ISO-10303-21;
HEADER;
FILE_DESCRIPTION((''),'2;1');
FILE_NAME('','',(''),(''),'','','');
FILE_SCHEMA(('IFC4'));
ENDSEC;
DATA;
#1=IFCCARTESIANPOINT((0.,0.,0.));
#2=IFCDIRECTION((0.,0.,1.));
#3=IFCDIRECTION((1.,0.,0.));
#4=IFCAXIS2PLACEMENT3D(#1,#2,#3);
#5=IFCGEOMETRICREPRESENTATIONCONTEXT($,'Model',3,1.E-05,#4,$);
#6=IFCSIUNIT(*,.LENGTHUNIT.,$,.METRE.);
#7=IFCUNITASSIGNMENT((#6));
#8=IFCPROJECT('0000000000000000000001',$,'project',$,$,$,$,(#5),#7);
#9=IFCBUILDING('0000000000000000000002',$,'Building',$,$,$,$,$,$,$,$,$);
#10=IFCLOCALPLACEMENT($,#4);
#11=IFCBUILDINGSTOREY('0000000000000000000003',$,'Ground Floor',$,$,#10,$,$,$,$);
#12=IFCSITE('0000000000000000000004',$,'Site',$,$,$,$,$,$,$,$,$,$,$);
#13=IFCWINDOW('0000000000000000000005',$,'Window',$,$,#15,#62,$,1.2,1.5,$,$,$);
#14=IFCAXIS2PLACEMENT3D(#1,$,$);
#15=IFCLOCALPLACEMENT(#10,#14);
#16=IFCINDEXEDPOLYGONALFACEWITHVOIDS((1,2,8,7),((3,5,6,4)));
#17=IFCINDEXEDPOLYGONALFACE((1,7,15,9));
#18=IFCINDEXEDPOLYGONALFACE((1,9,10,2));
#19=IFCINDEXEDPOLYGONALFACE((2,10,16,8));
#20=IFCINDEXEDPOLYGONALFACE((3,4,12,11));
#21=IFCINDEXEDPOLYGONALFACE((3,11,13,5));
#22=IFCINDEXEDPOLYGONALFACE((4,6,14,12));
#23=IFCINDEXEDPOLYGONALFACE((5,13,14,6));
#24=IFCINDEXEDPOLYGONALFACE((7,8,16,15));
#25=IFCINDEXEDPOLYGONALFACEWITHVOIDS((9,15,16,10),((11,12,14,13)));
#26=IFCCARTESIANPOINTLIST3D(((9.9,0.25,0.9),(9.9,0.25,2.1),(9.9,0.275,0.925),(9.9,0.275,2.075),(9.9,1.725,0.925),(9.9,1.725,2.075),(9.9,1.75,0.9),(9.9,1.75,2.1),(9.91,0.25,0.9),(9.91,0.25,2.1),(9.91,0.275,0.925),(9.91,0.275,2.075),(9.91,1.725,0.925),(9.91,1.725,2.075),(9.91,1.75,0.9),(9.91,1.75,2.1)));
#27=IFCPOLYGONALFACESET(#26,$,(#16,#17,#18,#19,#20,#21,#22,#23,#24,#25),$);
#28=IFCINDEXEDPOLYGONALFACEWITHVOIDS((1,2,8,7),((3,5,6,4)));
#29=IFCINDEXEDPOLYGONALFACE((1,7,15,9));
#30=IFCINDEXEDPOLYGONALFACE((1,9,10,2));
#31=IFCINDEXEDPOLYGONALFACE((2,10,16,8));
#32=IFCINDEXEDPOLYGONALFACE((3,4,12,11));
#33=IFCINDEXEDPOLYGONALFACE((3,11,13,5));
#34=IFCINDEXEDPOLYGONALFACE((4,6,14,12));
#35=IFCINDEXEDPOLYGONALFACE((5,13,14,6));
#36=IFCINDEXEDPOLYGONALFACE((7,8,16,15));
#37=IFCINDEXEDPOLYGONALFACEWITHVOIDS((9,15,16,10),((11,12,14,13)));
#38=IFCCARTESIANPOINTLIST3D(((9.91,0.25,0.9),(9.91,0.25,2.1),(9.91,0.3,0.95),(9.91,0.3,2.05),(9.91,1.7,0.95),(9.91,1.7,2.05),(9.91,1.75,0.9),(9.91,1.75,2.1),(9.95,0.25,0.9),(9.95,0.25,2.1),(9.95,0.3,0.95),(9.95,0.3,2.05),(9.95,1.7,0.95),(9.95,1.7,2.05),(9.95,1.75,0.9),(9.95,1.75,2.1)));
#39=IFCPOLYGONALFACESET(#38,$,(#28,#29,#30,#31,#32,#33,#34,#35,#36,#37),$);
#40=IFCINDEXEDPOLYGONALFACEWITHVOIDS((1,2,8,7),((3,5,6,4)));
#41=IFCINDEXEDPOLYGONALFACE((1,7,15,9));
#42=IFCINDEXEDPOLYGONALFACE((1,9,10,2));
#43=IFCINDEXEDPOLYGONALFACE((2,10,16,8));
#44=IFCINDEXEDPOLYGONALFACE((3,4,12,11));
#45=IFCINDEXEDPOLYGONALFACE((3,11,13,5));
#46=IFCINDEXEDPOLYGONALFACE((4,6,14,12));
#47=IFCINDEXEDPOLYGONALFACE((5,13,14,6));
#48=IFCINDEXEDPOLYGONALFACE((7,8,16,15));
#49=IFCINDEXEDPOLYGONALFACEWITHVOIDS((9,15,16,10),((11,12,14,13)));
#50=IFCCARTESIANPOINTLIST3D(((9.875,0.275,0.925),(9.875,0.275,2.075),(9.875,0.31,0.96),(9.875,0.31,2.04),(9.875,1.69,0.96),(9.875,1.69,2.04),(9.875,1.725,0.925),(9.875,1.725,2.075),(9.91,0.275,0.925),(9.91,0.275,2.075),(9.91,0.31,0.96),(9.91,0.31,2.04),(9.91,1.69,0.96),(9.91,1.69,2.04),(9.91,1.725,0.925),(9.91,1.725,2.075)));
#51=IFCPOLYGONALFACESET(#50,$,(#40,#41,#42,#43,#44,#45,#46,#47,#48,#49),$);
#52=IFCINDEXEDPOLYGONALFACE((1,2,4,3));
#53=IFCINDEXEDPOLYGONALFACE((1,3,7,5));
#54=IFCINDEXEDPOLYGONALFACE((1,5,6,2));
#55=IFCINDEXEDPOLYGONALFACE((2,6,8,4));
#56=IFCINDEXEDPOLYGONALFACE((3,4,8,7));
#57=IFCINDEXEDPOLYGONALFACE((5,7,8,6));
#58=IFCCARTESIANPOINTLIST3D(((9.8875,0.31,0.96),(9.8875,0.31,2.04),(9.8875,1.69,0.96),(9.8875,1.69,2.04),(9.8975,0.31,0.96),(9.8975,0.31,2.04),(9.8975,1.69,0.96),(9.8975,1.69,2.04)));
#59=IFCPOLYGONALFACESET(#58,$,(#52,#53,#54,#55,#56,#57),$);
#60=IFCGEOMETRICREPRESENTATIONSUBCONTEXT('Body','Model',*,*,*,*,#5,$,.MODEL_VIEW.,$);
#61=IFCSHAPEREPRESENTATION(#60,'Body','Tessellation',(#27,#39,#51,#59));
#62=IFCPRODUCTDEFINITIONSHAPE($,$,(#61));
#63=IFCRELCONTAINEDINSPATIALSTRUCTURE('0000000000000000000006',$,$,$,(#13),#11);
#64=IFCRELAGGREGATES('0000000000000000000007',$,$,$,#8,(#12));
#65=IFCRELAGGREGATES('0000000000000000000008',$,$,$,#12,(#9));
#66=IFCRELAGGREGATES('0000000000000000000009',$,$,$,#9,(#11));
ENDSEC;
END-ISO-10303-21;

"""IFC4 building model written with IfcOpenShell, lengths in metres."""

from ifc_helpers import new_model, si_unit, frame, origin_with_axes, place, context, subcontext, project, spatial, line, indexed_curve, outline, extrude, element, save


model = new_model("IFC4")

# Units and contexts
model_context = context("Model", 3, precision=1e-05, world=origin_with_axes())
body_context = subcontext(model_context, "Body", "Model", "MODEL_VIEW")
ifc_project = project(units=[si_unit("LENGTHUNIT", "METRE")], contexts=[model_context])

# Site, building, storey
site = spatial("IfcSite", under=ifc_project, Name="Site")
building = spatial("IfcBuilding", under=site, Name="Building")
storey_placement = place(None, origin_with_axes())
storey = spatial("IfcBuildingStorey", under=building, at=storey_placement, Name="Ground Floor")

# Window
window_1_placement = place(storey_placement, frame((10.0, 0.25, 0.9), z_axis=(0.0, 0.0, 1.0), x_axis=(0.0, 1.0, 0.0)))
element("IfcWindow", 1, at=window_1_placement, inside=storey, Name="Window", OverallHeight=1.2, OverallWidth=1.5, context=body_context, shape_type="SweptSolid", body=[
    extrude(outline(indexed_curve([(0.0, 0.0), (1.5, 0.0), (1.5, 1.2), (0.0, 1.2)], segments=[line(1, 2, 3, 4, 1)]), holes=[indexed_curve([(0.025, 0.025), (1.475, 0.025), (1.475, 1.175), (0.025, 1.175)], segments=[line(1, 2, 3, 4, 1)])]), frame((0.0, 0.09, 0.0), z_axis=(0.0, -1.0, 0.0), x_axis=(1.0, 0.0, 0.0)), (0.0, 0.0, -1.0), 0.01),
    extrude(outline(indexed_curve([(0.0, 0.0), (1.5, 0.0), (1.5, 1.2), (0.0, 1.2)], segments=[line(1, 2, 3, 4, 1)]), holes=[indexed_curve([(0.05, 0.05), (1.45, 0.05), (1.45, 1.15), (0.05, 1.15)], segments=[line(1, 2, 3, 4, 1)])]), frame((0.0, 0.05, 0.0), z_axis=(0.0, -1.0, 0.0), x_axis=(1.0, 0.0, 0.0)), (0.0, 0.0, -1.0), 0.04),
    extrude(outline(indexed_curve([(0.0, 0.0), (1.45, 0.0), (1.45, 1.15), (0.0, 1.15)], segments=[line(1, 2, 3, 4, 1)]), holes=[indexed_curve([(0.035, 0.035), (1.415, 0.035), (1.415, 1.115), (0.035, 1.115)], segments=[line(1, 2, 3, 4, 1)])]), frame((0.025, 0.09, 0.025), z_axis=(0.0, -1.0, 0.0), x_axis=(1.0, 0.0, 0.0)), (0.0, 0.0, -1.0), 0.035),
    extrude(outline(indexed_curve([(0.035, 0.035), (1.415, 0.035), (1.415, 1.115), (0.035, 1.115)], segments=[line(1, 2, 3, 4, 1)])), frame((0.025, 0.1025, 0.025), z_axis=(0.0, -1.0, 0.0), x_axis=(1.0, 0.0, 0.0)), (0.0, 0.0, -1.0), 0.01),
])

save(model, "model.ifc")
